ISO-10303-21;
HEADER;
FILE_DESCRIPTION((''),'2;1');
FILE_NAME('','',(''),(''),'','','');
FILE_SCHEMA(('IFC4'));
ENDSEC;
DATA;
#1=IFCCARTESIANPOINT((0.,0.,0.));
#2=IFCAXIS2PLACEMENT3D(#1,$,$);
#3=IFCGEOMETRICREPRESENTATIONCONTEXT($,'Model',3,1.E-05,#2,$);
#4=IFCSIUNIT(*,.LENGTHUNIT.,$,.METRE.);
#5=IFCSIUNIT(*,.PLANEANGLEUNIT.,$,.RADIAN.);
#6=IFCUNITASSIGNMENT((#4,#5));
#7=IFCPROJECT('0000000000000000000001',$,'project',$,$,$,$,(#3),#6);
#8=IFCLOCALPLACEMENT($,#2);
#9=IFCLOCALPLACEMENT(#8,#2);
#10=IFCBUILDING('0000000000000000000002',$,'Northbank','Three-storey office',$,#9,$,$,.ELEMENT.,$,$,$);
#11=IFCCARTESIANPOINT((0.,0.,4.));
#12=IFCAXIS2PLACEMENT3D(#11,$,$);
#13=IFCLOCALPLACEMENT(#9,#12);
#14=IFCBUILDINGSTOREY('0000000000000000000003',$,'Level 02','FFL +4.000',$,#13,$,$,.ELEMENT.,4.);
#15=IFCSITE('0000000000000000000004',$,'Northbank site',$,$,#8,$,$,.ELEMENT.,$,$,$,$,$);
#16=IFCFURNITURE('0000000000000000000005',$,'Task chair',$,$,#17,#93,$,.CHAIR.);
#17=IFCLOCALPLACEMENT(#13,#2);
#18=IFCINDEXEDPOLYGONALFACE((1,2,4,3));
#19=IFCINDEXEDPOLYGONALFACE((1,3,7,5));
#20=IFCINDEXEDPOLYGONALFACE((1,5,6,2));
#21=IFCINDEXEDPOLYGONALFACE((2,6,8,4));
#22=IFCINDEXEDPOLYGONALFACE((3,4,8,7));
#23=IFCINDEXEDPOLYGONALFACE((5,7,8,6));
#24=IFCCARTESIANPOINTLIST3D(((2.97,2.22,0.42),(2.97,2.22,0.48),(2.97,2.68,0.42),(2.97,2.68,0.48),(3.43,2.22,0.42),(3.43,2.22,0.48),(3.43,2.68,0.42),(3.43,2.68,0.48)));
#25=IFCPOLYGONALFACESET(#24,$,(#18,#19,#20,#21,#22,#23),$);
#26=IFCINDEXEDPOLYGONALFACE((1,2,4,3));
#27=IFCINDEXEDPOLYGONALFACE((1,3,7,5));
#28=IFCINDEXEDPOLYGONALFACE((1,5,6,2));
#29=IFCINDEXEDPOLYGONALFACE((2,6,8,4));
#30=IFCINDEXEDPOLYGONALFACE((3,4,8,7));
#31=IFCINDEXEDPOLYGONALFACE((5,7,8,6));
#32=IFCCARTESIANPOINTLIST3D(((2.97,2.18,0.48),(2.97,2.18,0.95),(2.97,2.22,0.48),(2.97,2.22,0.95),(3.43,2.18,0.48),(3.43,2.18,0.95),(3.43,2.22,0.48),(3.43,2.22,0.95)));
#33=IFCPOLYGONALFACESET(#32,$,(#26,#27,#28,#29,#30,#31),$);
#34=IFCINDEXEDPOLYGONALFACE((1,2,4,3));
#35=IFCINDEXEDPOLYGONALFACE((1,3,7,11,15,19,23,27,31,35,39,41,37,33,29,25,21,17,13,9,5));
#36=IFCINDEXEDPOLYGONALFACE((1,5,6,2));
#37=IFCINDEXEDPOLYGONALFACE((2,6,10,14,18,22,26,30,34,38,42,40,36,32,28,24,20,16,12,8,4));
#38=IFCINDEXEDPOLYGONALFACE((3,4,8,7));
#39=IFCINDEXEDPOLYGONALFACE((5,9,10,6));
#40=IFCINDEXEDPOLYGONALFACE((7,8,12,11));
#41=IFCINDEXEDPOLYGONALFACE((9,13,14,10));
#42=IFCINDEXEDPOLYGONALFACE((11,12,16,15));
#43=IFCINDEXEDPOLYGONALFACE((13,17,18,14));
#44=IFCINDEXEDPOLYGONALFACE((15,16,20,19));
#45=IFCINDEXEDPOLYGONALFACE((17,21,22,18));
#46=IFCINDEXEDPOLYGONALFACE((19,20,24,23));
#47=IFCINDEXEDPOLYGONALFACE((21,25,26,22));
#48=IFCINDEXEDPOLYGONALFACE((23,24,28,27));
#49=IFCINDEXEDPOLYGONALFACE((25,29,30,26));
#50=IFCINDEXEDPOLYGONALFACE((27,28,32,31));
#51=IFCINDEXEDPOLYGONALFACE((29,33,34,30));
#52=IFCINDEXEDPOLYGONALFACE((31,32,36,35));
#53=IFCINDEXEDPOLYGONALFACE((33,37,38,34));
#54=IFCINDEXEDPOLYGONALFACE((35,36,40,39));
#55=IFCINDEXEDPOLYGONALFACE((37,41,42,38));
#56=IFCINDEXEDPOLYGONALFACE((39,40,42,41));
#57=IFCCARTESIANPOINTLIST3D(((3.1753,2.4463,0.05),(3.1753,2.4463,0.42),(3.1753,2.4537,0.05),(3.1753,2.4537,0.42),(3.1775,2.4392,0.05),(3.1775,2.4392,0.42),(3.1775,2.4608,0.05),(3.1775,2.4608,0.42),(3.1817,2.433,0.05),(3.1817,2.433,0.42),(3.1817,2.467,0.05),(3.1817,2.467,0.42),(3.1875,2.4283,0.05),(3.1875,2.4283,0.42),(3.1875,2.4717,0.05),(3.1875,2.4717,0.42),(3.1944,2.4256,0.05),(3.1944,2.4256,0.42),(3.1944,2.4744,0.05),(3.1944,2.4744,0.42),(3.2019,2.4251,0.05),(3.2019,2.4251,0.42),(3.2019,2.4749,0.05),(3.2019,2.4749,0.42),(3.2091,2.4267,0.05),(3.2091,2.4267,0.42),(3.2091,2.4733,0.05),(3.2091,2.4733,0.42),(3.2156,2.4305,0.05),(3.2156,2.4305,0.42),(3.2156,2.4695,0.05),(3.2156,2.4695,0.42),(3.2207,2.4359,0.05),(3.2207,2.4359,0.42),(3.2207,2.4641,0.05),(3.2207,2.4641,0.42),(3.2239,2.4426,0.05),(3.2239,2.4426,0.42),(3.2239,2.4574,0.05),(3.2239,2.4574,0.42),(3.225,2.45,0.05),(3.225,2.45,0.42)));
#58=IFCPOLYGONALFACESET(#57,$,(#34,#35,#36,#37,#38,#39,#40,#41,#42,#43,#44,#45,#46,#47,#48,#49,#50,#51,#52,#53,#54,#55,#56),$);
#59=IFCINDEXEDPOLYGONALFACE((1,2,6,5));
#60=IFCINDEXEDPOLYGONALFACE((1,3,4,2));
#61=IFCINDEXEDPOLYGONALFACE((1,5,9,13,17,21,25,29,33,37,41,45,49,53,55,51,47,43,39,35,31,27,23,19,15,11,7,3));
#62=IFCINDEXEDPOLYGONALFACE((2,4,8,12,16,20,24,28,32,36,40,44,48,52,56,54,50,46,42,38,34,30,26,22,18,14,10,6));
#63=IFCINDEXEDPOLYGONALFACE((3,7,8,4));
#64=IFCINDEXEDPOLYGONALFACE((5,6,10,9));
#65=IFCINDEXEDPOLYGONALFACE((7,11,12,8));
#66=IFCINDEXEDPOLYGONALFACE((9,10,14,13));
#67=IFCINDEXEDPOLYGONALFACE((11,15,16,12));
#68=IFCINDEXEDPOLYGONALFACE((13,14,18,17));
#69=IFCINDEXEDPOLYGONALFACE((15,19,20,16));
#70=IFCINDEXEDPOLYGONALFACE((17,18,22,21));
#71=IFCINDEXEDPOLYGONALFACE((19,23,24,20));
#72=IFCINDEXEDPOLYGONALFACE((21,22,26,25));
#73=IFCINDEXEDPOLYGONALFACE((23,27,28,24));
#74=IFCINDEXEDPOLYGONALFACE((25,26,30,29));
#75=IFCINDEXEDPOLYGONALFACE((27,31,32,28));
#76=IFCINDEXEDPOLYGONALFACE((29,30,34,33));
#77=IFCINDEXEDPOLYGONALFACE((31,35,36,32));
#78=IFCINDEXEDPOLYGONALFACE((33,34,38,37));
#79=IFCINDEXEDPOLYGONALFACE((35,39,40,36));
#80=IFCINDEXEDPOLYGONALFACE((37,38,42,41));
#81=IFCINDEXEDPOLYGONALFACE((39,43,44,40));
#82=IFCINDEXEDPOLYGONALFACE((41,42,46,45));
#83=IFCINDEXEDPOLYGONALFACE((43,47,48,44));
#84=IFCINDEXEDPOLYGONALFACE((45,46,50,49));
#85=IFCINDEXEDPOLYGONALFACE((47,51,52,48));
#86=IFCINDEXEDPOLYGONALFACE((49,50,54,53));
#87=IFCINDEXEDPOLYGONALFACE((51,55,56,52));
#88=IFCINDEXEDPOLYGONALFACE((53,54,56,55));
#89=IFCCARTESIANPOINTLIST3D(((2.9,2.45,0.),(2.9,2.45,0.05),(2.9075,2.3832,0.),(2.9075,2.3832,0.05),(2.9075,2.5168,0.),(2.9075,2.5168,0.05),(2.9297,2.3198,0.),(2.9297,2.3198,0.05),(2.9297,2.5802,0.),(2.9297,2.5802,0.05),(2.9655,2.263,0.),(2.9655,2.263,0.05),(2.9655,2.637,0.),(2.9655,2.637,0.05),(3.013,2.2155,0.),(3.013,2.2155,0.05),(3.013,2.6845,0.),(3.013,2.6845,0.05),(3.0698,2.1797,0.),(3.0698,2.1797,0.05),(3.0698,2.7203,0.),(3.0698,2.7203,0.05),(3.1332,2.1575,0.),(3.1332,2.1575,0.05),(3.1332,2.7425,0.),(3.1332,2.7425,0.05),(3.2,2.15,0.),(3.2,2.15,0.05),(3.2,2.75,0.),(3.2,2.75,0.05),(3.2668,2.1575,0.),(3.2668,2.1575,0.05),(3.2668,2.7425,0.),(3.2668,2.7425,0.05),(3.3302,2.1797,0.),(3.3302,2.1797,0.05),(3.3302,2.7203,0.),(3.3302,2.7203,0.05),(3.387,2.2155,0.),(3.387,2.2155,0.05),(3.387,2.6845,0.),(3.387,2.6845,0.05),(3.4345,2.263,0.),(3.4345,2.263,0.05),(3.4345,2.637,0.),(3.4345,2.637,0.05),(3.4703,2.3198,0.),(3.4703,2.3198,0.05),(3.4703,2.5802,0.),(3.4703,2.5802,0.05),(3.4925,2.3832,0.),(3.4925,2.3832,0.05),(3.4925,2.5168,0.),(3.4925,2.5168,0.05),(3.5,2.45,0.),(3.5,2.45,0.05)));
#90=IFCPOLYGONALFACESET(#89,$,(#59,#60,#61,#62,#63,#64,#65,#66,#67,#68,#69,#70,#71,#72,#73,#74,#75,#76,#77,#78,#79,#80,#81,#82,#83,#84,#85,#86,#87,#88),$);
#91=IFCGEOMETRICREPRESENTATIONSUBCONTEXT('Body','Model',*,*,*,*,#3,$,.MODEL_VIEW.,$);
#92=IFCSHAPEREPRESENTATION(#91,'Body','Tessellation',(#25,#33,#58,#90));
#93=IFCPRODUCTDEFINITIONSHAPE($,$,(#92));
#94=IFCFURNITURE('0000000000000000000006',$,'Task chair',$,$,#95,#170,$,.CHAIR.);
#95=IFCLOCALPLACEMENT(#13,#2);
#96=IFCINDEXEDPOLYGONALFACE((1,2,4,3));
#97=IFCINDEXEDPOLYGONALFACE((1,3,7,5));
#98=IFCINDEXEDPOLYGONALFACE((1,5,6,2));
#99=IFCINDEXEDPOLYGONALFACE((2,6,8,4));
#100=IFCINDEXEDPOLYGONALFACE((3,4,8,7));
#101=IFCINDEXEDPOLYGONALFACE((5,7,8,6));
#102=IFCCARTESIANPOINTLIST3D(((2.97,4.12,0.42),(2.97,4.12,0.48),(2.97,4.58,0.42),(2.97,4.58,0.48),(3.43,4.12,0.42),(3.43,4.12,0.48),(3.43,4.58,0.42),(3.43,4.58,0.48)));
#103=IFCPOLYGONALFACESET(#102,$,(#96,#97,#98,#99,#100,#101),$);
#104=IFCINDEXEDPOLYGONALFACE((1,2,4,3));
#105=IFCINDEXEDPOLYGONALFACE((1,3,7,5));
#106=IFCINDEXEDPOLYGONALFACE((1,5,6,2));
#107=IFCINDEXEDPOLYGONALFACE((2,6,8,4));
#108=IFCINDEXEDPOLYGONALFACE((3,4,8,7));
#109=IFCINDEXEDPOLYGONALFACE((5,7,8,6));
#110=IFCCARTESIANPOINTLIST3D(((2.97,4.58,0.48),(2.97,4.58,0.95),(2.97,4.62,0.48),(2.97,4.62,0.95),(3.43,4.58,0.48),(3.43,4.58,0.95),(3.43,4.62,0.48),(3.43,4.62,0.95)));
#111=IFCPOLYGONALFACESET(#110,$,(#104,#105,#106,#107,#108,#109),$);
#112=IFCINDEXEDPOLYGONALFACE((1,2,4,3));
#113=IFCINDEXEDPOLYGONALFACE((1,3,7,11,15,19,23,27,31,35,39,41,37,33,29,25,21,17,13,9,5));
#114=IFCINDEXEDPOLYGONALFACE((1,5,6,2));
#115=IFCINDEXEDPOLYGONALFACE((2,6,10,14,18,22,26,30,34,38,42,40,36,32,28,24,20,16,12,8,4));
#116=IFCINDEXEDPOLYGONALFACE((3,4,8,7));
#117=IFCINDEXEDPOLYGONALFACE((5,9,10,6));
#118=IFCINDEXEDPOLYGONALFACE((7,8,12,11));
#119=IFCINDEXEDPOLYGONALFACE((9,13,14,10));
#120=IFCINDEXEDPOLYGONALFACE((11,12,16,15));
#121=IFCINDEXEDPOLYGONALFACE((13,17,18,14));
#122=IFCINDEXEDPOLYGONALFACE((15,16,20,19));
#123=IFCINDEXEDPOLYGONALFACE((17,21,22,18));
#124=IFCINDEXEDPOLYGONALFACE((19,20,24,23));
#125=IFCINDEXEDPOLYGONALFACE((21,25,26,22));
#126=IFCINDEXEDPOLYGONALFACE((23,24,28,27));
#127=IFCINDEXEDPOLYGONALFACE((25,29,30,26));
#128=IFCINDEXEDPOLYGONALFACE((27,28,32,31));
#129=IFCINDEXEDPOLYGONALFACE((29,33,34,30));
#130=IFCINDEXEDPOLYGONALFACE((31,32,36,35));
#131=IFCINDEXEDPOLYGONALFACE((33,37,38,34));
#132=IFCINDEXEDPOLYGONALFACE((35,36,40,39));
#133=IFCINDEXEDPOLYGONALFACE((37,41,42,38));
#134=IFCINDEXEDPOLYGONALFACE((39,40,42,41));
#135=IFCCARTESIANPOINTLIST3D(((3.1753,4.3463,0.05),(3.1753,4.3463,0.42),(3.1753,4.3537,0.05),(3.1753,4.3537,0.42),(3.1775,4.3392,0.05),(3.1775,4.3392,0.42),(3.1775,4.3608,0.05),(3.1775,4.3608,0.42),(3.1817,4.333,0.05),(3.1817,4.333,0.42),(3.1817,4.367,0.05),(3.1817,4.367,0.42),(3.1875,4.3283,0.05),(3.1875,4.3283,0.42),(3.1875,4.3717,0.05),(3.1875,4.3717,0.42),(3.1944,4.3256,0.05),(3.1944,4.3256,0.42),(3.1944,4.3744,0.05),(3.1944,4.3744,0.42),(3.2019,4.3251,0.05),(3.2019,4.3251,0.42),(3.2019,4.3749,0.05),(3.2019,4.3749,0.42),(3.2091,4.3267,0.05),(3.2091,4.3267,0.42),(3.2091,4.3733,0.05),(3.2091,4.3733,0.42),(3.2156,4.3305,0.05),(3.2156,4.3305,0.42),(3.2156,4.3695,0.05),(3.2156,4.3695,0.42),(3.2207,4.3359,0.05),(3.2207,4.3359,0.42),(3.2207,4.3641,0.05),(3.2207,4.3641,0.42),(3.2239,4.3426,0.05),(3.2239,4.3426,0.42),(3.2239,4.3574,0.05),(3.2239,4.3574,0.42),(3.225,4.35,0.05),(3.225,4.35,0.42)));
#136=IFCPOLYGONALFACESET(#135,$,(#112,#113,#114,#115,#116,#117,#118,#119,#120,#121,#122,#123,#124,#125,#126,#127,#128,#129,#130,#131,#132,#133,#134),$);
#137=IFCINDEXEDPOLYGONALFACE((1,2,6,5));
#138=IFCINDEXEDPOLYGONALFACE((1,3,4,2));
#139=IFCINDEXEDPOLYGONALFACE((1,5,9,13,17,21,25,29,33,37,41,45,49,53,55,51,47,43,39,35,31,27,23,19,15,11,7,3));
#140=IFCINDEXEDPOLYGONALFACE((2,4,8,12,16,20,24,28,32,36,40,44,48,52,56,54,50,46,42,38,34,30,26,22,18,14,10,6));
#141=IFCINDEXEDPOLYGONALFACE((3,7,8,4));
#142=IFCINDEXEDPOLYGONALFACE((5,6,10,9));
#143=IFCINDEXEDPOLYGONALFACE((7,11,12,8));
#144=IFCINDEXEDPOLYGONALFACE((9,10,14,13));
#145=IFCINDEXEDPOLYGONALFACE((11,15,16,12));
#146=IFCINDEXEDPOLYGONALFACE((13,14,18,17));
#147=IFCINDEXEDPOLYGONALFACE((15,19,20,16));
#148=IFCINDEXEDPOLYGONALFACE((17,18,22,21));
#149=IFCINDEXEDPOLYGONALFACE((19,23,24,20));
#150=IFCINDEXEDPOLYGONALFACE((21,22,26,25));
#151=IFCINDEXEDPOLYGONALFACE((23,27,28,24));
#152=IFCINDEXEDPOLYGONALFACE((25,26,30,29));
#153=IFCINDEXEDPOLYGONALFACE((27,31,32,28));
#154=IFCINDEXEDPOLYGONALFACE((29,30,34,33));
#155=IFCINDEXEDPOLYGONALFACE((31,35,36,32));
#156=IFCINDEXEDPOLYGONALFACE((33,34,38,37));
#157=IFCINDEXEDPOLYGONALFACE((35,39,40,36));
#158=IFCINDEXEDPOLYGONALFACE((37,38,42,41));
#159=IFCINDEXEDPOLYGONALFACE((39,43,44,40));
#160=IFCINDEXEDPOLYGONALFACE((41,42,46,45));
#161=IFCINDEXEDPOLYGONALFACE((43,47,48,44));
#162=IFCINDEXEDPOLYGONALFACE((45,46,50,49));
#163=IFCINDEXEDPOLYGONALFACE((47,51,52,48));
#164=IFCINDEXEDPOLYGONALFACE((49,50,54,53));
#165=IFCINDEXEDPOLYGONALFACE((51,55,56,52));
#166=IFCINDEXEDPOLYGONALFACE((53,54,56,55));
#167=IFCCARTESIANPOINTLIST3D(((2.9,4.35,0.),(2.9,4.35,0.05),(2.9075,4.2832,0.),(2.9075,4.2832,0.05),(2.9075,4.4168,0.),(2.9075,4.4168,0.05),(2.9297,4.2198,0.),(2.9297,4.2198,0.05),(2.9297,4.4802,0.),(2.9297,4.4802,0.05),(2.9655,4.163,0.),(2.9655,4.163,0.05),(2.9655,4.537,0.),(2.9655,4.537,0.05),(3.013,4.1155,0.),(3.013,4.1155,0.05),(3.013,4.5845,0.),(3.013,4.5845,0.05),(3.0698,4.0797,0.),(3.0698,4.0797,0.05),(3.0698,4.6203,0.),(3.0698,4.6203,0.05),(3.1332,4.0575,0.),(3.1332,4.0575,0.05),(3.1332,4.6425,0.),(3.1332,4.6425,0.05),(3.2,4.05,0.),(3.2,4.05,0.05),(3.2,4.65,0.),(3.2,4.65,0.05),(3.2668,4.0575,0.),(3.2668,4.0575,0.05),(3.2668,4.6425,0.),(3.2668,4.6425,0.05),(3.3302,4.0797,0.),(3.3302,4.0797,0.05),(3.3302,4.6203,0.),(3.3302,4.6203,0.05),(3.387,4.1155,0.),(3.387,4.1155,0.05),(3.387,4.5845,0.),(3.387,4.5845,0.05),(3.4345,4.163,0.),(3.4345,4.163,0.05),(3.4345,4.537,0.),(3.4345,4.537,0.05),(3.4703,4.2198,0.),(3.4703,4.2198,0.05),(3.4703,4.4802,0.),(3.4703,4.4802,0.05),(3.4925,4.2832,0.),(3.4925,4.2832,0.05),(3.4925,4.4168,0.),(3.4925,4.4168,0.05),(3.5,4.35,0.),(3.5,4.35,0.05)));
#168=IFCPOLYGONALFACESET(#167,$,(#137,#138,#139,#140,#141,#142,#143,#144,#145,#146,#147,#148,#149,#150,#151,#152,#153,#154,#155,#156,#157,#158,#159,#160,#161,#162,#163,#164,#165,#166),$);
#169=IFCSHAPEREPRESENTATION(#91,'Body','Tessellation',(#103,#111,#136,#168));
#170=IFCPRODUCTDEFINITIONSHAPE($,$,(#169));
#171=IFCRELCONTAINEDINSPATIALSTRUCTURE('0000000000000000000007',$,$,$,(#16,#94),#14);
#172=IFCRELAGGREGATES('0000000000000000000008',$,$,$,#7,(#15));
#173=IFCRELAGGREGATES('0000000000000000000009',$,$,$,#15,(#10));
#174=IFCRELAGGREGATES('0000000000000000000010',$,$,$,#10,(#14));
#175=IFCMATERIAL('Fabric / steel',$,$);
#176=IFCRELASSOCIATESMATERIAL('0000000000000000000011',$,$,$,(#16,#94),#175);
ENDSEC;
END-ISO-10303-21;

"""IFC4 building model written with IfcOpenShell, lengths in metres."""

from ifc_helpers import new_model, si_unit, frame, origin, place, context, subcontext, project, spatial, rectangle, circle, extrude, material, element, save


model = new_model("IFC4")

# Units and contexts
model_context = context("Model", 3, precision=1e-05, world=origin())
body_context = subcontext(model_context, "Body", "Model", "MODEL_VIEW")
ifc_project = project(units=[si_unit("LENGTHUNIT", "METRE"), si_unit("PLANEANGLEUNIT", "RADIAN")], contexts=[model_context])

# Site, building, storey
site_placement = place(None, origin())
site = spatial("IfcSite", under=ifc_project, at=site_placement, Name="Northbank site", CompositionType="ELEMENT")
building_placement = place(site_placement, origin())
building = spatial("IfcBuilding", under=site, at=building_placement, Name="Northbank", Description="Three-storey office", CompositionType="ELEMENT")
storey_placement = place(building_placement, frame((0.0, 0.0, 4.0)))
storey = spatial("IfcBuildingStorey", under=building, at=storey_placement, Name="Level 02", Description="FFL +4.000", CompositionType="ELEMENT", Elevation=4.0)

# Furniture
ifc_material_1 = material(Name="Fabric / steel")
furniture_1_placement = place(storey_placement, frame((0.0, 0.0, -4.0)))
element("IfcFurniture", 1, at=furniture_1_placement, inside=storey, material=ifc_material_1, Name="Task chair", PredefinedType="CHAIR", context=body_context, shape_type="SweptSolid", body=[
    extrude(rectangle(XDim=0.46, YDim=0.46), frame((3.2, 2.45, 4.42)), (0.0, 0.0, 1.0), 0.06),
    extrude(rectangle(XDim=0.46, YDim=0.04), frame((3.2, 2.2, 4.48)), (0.0, 0.0, 1.0), 0.47),
    extrude(circle(Radius=0.025), frame((3.2, 2.45, 4.05), z_axis=(0.0, 0.0, 1.0), x_axis=(1.0, 0.0, 0.0)), (0.0, 0.0, 1.0), 0.37),
    extrude(circle(Radius=0.3), frame((3.2, 2.45, 4.0), z_axis=(0.0, 0.0, 1.0), x_axis=(1.0, 0.0, 0.0)), (0.0, 0.0, 1.0), 0.05),
])
furniture_2_placement = place(storey_placement, frame((0.0, 0.0, -4.0)))
element("IfcFurniture", 2, at=furniture_2_placement, inside=storey, material=ifc_material_1, Name="Task chair", PredefinedType="CHAIR", context=body_context, shape_type="SweptSolid", body=[
    extrude(rectangle(XDim=0.46, YDim=0.46), frame((3.2, 4.35, 4.42)), (0.0, 0.0, 1.0), 0.06),
    extrude(rectangle(XDim=0.46, YDim=0.04), frame((3.2, 4.6, 4.48)), (0.0, 0.0, 1.0), 0.47),
    extrude(circle(Radius=0.025), frame((3.2, 4.35, 4.05), z_axis=(0.0, 0.0, 1.0), x_axis=(1.0, 0.0, 0.0)), (0.0, 0.0, 1.0), 0.37),
    extrude(circle(Radius=0.3), frame((3.2, 4.35, 4.0), z_axis=(0.0, 0.0, 1.0), x_axis=(1.0, 0.0, 0.0)), (0.0, 0.0, 1.0), 0.05),
])

save(model, "model.ifc")
